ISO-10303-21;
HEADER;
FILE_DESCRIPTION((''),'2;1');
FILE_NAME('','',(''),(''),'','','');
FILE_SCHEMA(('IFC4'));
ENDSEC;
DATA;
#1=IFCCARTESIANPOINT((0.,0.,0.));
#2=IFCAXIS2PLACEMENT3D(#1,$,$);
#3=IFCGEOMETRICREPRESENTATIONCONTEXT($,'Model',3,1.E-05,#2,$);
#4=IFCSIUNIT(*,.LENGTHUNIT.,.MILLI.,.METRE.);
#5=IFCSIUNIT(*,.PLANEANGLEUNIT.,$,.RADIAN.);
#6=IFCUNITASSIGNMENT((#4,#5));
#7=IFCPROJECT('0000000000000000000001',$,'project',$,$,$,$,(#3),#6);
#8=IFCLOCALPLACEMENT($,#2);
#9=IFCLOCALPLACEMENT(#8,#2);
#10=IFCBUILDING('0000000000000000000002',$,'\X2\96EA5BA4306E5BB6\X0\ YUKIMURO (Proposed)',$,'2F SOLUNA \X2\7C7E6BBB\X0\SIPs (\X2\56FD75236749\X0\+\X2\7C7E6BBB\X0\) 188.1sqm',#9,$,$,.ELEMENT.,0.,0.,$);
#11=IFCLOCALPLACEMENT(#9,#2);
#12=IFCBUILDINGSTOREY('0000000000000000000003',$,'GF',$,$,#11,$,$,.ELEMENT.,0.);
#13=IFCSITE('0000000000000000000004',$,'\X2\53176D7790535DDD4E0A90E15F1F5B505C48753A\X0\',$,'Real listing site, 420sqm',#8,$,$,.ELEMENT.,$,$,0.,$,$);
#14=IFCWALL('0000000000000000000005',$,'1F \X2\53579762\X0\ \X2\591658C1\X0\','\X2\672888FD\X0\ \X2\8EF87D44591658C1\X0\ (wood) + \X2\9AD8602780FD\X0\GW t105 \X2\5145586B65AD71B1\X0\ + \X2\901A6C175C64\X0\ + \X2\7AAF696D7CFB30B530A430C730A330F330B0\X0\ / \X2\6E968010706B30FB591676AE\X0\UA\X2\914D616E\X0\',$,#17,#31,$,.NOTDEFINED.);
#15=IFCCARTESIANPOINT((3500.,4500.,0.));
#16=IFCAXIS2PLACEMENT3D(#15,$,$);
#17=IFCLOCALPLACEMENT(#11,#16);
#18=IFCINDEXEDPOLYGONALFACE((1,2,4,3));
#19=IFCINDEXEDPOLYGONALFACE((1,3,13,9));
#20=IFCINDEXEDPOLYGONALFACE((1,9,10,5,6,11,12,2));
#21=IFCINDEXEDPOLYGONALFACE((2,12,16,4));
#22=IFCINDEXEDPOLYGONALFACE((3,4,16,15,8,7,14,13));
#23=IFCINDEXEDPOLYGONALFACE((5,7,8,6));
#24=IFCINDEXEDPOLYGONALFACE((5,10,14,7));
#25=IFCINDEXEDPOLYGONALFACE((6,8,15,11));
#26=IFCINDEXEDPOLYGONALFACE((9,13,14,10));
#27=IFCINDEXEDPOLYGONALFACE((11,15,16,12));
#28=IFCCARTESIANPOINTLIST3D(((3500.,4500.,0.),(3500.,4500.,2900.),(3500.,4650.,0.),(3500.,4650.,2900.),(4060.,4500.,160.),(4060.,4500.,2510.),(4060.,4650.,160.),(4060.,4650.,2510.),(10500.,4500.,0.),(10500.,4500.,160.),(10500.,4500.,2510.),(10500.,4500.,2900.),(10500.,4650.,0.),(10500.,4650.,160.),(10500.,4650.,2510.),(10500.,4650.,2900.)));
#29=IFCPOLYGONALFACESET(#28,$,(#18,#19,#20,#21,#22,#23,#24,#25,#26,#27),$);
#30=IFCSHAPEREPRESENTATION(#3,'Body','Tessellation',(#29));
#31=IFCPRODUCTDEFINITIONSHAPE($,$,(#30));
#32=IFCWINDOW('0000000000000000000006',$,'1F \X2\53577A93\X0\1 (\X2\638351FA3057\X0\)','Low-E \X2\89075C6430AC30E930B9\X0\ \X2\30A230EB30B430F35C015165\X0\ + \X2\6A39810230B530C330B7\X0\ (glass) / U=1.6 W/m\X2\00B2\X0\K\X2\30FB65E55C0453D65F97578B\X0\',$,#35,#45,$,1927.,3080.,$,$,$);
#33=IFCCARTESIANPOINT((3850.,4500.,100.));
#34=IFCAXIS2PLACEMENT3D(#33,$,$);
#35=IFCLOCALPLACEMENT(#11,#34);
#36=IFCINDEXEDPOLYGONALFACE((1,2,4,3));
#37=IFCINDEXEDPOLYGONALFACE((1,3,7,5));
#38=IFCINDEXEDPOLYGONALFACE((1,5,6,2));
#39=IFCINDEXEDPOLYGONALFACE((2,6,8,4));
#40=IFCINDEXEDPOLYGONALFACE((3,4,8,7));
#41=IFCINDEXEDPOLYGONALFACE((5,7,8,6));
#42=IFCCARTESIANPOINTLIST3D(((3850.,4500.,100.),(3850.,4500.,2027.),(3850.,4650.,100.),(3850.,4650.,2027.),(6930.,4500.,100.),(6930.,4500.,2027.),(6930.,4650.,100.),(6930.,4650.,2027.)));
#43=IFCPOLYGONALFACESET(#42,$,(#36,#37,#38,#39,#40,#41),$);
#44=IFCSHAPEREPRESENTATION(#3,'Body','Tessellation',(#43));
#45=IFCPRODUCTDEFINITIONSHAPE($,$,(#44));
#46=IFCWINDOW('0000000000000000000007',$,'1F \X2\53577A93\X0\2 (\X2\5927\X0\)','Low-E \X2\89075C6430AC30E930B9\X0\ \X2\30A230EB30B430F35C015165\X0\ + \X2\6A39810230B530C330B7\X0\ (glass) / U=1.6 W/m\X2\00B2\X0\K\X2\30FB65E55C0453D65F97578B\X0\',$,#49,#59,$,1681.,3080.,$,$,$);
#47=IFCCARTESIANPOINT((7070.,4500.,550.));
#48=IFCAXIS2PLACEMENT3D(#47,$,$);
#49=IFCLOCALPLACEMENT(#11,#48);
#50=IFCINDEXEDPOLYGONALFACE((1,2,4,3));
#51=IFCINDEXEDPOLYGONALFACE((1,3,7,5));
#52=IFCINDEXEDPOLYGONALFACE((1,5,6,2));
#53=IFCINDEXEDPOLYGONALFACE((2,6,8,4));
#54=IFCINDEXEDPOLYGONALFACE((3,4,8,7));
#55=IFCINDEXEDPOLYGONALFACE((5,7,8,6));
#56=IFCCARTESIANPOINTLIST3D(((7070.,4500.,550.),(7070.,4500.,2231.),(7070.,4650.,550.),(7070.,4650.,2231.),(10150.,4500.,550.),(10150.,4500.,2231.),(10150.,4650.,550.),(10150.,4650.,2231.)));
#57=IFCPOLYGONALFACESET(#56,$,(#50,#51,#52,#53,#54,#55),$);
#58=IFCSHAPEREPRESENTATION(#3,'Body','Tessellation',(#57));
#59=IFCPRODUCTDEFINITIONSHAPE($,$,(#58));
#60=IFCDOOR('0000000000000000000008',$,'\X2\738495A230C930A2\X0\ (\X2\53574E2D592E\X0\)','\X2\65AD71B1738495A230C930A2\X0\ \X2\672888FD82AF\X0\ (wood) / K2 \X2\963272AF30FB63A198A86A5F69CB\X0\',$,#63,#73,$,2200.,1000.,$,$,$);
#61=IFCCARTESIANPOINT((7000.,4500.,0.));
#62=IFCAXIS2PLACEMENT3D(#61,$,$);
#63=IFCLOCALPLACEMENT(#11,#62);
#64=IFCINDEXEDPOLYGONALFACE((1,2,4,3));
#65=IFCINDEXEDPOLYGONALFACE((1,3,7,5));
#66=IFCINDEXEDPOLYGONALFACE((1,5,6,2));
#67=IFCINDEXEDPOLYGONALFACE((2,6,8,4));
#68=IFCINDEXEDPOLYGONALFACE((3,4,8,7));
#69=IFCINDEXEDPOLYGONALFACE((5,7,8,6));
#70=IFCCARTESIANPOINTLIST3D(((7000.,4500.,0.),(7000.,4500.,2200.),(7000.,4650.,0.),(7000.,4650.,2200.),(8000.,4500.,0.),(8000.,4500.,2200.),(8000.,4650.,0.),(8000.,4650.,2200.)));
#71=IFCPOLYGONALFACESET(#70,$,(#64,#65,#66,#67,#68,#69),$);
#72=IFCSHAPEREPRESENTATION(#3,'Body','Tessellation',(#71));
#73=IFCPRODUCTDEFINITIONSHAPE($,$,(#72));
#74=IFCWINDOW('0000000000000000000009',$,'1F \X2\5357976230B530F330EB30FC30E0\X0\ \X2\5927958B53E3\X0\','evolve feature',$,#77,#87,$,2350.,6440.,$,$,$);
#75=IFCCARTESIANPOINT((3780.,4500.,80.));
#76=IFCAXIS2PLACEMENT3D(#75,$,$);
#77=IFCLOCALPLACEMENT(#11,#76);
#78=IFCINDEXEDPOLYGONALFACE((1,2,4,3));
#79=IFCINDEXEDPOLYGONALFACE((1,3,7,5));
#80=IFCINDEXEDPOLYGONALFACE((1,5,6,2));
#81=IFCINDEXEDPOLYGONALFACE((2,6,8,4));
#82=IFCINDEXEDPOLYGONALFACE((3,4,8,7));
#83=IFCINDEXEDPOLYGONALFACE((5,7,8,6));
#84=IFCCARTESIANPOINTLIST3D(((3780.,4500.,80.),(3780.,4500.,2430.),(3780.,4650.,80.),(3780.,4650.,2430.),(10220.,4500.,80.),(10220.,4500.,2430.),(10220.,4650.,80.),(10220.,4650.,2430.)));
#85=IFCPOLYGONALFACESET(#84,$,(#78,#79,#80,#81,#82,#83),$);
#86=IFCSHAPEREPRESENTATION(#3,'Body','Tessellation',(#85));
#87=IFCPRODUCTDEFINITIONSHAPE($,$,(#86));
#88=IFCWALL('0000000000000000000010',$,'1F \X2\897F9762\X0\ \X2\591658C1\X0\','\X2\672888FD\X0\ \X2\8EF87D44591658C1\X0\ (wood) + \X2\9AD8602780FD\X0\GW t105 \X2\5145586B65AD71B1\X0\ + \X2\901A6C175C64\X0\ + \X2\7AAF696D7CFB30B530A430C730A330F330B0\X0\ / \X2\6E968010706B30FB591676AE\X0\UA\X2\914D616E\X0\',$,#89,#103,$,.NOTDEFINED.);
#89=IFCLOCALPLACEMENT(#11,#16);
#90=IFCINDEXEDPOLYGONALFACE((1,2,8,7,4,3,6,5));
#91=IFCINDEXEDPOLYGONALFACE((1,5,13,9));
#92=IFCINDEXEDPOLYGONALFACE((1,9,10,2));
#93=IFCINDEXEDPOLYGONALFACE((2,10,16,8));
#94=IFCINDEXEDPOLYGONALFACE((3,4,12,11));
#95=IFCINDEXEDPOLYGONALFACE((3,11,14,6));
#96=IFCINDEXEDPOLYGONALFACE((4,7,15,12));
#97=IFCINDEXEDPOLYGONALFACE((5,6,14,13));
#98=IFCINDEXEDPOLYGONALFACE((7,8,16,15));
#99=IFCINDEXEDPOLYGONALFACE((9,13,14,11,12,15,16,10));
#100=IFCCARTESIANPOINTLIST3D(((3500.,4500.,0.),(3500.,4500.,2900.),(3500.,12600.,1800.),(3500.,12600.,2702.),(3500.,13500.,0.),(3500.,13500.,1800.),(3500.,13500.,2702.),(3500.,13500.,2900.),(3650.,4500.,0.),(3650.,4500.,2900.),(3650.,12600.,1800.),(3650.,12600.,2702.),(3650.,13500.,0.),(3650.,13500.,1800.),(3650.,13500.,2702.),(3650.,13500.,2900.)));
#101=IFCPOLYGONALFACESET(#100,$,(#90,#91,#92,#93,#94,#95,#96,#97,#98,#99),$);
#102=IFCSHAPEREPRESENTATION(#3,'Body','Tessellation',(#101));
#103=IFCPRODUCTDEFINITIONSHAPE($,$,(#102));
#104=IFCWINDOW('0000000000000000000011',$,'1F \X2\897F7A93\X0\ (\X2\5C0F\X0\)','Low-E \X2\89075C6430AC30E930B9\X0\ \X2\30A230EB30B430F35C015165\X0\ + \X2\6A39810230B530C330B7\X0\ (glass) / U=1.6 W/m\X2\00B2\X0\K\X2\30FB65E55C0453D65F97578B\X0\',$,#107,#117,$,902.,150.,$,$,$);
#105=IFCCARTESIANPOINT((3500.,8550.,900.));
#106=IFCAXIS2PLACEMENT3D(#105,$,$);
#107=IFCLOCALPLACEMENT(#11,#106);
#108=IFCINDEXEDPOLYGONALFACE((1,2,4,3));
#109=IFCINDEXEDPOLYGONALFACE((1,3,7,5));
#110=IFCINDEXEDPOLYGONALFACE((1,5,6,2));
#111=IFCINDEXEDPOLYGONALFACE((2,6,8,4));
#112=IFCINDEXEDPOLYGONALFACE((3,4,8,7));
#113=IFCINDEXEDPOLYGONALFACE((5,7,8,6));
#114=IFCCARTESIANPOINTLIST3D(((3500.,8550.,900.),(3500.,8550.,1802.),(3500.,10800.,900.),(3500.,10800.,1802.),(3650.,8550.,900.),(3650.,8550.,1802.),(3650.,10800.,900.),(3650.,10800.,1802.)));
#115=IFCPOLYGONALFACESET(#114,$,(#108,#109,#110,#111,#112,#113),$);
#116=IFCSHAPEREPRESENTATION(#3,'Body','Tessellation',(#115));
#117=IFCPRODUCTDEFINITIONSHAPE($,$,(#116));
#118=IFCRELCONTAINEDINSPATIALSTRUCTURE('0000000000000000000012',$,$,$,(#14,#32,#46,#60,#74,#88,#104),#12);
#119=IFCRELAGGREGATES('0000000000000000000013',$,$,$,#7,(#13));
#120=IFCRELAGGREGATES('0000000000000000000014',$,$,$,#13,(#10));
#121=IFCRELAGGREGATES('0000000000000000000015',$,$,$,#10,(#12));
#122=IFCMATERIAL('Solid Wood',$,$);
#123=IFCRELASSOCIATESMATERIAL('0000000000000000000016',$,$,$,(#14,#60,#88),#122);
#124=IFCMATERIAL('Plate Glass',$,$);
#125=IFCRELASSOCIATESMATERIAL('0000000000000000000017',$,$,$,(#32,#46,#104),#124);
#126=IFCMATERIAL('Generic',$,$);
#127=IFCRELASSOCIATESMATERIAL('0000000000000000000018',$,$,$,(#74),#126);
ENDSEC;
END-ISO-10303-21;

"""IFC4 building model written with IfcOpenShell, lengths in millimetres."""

from ifc_helpers import new_model, si_unit, frame, frame_2d, origin, place, context, project, spatial, rectangle, extrude, material, element, fill, save


model = new_model("IFC4")

# Units and contexts
model_context = context("Model", 3, precision=1e-05, world=origin())
ifc_project = project(units=[si_unit("LENGTHUNIT", "METRE", prefix="MILLI"), si_unit("PLANEANGLEUNIT", "RADIAN")], contexts=[model_context])

# Site, building, storey
site_placement = place(None, origin())
site = spatial("IfcSite", under=ifc_project, at=site_placement, Name="北海道川上郡弟子屈町", ObjectType="Real listing site, 420sqm", CompositionType="ELEMENT", RefElevation=0.0)
building_placement = place(site_placement, origin())
building = spatial("IfcBuilding", under=site, at=building_placement, Name="雪室の家 YUKIMURO (Proposed)", ObjectType="2F SOLUNA 籾殻SIPs (国産杉+籾殻) 188.1sqm", CompositionType="ELEMENT", ElevationOfRefHeight=0.0, ElevationOfTerrain=0.0)
storey_placement = place(building_placement, origin())
storey = spatial("IfcBuildingStorey", under=building, at=storey_placement, Name="GF", CompositionType="ELEMENT", Elevation=0.0)

# Shared definitions
ifc_material_1 = material(Name="Solid Wood")

# Wall, openings, windows, door
wall_1_placement = place(storey_placement, frame((3500.0, 4500.0, 0.0)))
wall_1 = element("IfcWall", 1, at=wall_1_placement, inside=storey, material=ifc_material_1, Name="1F 南面 外壁", Description="木製 軸組外壁 (wood) + 高性能GW t105 充填断熱 + 通気層 + 窯業系サイディング / 準耐火・外皮UA配慮", PredefinedType="NOTDEFINED", context=model_context, shape_type="SweptSolid", body=[
    extrude(rectangle(XDim=7000.0, YDim=150.0, at=frame_2d((3500.0, 75.0))), frame((3500.0, 4500.0, 0.0)), (0.0, 0.0, 1.0), 2900.0),
])
opening_1_placement = place(storey_placement, frame((3850.0, 4500.0, 100.0)))
opening_1 = element("IfcOpeningElement", 2, at=opening_1_placement, cuts=wall_1, PredefinedType="NOTDEFINED", context=model_context, shape_type="SweptSolid", body=[
    extrude(rectangle(XDim=3080.0, YDim=150.0, at=frame_2d((1540.0, 75.0))), frame((3850.0, 4500.0, 100.0)), (0.0, 0.0, 1.0), 1927.0),
])
opening_2_placement = place(storey_placement, frame((7070.0, 4500.0, 550.0)))
opening_2 = element("IfcOpeningElement", 3, at=opening_2_placement, cuts=wall_1, PredefinedType="NOTDEFINED", context=model_context, shape_type="SweptSolid", body=[
    extrude(rectangle(XDim=3080.0, YDim=150.0, at=frame_2d((1540.0, 75.0))), frame((7070.0, 4500.0, 550.0)), (0.0, 0.0, 1.0), 1681.0),
])
opening_3_placement = place(storey_placement, frame((7000.0, 4500.0, 0.0)))
opening_3 = element("IfcOpeningElement", 4, at=opening_3_placement, cuts=wall_1, PredefinedType="NOTDEFINED", context=model_context, shape_type="SweptSolid", body=[
    extrude(rectangle(XDim=1000.0, YDim=150.0, at=frame_2d((500.0, 75.0))), frame((7000.0, 4500.0, 0.0)), (0.0, 0.0, 1.0), 2200.0),
])
opening_4_placement = place(storey_placement, frame((3780.0, 4500.0, 80.0)))
opening_4 = element("IfcOpeningElement", 5, at=opening_4_placement, cuts=wall_1, PredefinedType="NOTDEFINED", context=model_context, shape_type="SweptSolid", body=[
    extrude(rectangle(XDim=6440.0, YDim=150.0, at=frame_2d((3220.0, 75.0))), frame((3780.0, 4500.0, 80.0)), (0.0, 0.0, 1.0), 2350.0),
])
ifc_material_2 = material(Name="Plate Glass")
window_1_placement = place(storey_placement, frame((3850.0, 4500.0, 100.0)))
window_1 = element("IfcWindow", 6, at=window_1_placement, inside=storey, material=ifc_material_2, Name="1F 南窓1 (掃出し)", Description="Low-E 複層ガラス アルゴン封入 + 樹脂サッシ (glass) / U=1.6 W/m²K・日射取得型", OverallHeight=1927.0, OverallWidth=3080.0, context=model_context, shape_type="SweptSolid", body=[
    extrude(rectangle(XDim=3080.0, YDim=150.0, at=frame_2d((1540.0, 75.0))), frame((3850.0, 4500.0, 100.0)), (0.0, 0.0, 1.0), 1927.0),
])
fill(opening_1, window_1)
window_2_placement = place(storey_placement, frame((7070.0, 4500.0, 550.0)))
window_2 = element("IfcWindow", 7, at=window_2_placement, inside=storey, material=ifc_material_2, Name="1F 南窓2 (大)", Description="Low-E 複層ガラス アルゴン封入 + 樹脂サッシ (glass) / U=1.6 W/m²K・日射取得型", OverallHeight=1681.0, OverallWidth=3080.0, context=model_context, shape_type="SweptSolid", body=[
    extrude(rectangle(XDim=3080.0, YDim=150.0, at=frame_2d((1540.0, 75.0))), frame((7070.0, 4500.0, 550.0)), (0.0, 0.0, 1.0), 1681.0),
])
fill(opening_2, window_2)
door_placement = place(storey_placement, frame((7000.0, 4500.0, 0.0)))
door = element("IfcDoor", 8, at=door_placement, inside=storey, material=ifc_material_1, Name="玄関ドア (南中央)", Description="断熱玄関ドア 木製芯 (wood) / K2 防犯・採風機構", OverallHeight=2200.0, OverallWidth=1000.0, context=model_context, shape_type="SweptSolid", body=[
    extrude(rectangle(XDim=1000.0, YDim=150.0, at=frame_2d((500.0, 75.0))), frame((7000.0, 4500.0, 0.0)), (0.0, 0.0, 1.0), 2200.0),
])
fill(opening_3, door)
ifc_material_3 = material(Name="Generic")
window_3_placement = place(storey_placement, frame((3780.0, 4500.0, 80.0)))
window_3 = element("IfcWindow", 9, at=window_3_placement, inside=storey, material=ifc_material_3, Name="1F 南面サンルーム 大開口", Description="evolve feature", OverallHeight=2350.0, OverallWidth=6440.0, context=model_context, shape_type="SweptSolid", body=[
    extrude(rectangle(XDim=6440.0, YDim=150.0, at=frame_2d((3220.0, 75.0))), frame((3780.0, 4500.0, 80.0)), (0.0, 0.0, 1.0), 2350.0),
])
fill(opening_4, window_3)

# Wall, opening, window
wall_2_placement = place(storey_placement, frame((3500.0, 4500.0, 0.0)))
wall_2 = element("IfcWall", 10, at=wall_2_placement, inside=storey, material=ifc_material_1, Name="1F 西面 外壁", Description="木製 軸組外壁 (wood) + 高性能GW t105 充填断熱 + 通気層 + 窯業系サイディング / 準耐火・外皮UA配慮", PredefinedType="NOTDEFINED", context=model_context, shape_type="SweptSolid", body=[
    extrude(rectangle(XDim=150.0, YDim=9000.0, at=frame_2d((75.0, 4500.0))), frame((3500.0, 4500.0, 0.0)), (0.0, 0.0, 1.0), 2900.0),
])
opening_5_placement = place(storey_placement, frame((3500.0, 8550.0, 900.0)))
opening_5 = element("IfcOpeningElement", 11, at=opening_5_placement, cuts=wall_2, PredefinedType="NOTDEFINED", context=model_context, shape_type="SweptSolid", body=[
    extrude(rectangle(XDim=150.0, YDim=2250.0, at=frame_2d((75.0, 1125.0))), frame((3500.0, 8550.0, 900.0)), (0.0, 0.0, 1.0), 902.0),
])
window_4_placement = place(storey_placement, frame((3500.0, 8550.0, 900.0)))
window_4 = element("IfcWindow", 12, at=window_4_placement, inside=storey, material=ifc_material_2, Name="1F 西窓 (小)", Description="Low-E 複層ガラス アルゴン封入 + 樹脂サッシ (glass) / U=1.6 W/m²K・日射取得型", OverallHeight=902.0, OverallWidth=150.0, context=model_context, shape_type="SweptSolid", body=[
    extrude(rectangle(XDim=150.0, YDim=2250.0, at=frame_2d((75.0, 1125.0))), frame((3500.0, 8550.0, 900.0)), (0.0, 0.0, 1.0), 902.0),
])
fill(opening_5, window_4)

save(model, "model.ifc")
